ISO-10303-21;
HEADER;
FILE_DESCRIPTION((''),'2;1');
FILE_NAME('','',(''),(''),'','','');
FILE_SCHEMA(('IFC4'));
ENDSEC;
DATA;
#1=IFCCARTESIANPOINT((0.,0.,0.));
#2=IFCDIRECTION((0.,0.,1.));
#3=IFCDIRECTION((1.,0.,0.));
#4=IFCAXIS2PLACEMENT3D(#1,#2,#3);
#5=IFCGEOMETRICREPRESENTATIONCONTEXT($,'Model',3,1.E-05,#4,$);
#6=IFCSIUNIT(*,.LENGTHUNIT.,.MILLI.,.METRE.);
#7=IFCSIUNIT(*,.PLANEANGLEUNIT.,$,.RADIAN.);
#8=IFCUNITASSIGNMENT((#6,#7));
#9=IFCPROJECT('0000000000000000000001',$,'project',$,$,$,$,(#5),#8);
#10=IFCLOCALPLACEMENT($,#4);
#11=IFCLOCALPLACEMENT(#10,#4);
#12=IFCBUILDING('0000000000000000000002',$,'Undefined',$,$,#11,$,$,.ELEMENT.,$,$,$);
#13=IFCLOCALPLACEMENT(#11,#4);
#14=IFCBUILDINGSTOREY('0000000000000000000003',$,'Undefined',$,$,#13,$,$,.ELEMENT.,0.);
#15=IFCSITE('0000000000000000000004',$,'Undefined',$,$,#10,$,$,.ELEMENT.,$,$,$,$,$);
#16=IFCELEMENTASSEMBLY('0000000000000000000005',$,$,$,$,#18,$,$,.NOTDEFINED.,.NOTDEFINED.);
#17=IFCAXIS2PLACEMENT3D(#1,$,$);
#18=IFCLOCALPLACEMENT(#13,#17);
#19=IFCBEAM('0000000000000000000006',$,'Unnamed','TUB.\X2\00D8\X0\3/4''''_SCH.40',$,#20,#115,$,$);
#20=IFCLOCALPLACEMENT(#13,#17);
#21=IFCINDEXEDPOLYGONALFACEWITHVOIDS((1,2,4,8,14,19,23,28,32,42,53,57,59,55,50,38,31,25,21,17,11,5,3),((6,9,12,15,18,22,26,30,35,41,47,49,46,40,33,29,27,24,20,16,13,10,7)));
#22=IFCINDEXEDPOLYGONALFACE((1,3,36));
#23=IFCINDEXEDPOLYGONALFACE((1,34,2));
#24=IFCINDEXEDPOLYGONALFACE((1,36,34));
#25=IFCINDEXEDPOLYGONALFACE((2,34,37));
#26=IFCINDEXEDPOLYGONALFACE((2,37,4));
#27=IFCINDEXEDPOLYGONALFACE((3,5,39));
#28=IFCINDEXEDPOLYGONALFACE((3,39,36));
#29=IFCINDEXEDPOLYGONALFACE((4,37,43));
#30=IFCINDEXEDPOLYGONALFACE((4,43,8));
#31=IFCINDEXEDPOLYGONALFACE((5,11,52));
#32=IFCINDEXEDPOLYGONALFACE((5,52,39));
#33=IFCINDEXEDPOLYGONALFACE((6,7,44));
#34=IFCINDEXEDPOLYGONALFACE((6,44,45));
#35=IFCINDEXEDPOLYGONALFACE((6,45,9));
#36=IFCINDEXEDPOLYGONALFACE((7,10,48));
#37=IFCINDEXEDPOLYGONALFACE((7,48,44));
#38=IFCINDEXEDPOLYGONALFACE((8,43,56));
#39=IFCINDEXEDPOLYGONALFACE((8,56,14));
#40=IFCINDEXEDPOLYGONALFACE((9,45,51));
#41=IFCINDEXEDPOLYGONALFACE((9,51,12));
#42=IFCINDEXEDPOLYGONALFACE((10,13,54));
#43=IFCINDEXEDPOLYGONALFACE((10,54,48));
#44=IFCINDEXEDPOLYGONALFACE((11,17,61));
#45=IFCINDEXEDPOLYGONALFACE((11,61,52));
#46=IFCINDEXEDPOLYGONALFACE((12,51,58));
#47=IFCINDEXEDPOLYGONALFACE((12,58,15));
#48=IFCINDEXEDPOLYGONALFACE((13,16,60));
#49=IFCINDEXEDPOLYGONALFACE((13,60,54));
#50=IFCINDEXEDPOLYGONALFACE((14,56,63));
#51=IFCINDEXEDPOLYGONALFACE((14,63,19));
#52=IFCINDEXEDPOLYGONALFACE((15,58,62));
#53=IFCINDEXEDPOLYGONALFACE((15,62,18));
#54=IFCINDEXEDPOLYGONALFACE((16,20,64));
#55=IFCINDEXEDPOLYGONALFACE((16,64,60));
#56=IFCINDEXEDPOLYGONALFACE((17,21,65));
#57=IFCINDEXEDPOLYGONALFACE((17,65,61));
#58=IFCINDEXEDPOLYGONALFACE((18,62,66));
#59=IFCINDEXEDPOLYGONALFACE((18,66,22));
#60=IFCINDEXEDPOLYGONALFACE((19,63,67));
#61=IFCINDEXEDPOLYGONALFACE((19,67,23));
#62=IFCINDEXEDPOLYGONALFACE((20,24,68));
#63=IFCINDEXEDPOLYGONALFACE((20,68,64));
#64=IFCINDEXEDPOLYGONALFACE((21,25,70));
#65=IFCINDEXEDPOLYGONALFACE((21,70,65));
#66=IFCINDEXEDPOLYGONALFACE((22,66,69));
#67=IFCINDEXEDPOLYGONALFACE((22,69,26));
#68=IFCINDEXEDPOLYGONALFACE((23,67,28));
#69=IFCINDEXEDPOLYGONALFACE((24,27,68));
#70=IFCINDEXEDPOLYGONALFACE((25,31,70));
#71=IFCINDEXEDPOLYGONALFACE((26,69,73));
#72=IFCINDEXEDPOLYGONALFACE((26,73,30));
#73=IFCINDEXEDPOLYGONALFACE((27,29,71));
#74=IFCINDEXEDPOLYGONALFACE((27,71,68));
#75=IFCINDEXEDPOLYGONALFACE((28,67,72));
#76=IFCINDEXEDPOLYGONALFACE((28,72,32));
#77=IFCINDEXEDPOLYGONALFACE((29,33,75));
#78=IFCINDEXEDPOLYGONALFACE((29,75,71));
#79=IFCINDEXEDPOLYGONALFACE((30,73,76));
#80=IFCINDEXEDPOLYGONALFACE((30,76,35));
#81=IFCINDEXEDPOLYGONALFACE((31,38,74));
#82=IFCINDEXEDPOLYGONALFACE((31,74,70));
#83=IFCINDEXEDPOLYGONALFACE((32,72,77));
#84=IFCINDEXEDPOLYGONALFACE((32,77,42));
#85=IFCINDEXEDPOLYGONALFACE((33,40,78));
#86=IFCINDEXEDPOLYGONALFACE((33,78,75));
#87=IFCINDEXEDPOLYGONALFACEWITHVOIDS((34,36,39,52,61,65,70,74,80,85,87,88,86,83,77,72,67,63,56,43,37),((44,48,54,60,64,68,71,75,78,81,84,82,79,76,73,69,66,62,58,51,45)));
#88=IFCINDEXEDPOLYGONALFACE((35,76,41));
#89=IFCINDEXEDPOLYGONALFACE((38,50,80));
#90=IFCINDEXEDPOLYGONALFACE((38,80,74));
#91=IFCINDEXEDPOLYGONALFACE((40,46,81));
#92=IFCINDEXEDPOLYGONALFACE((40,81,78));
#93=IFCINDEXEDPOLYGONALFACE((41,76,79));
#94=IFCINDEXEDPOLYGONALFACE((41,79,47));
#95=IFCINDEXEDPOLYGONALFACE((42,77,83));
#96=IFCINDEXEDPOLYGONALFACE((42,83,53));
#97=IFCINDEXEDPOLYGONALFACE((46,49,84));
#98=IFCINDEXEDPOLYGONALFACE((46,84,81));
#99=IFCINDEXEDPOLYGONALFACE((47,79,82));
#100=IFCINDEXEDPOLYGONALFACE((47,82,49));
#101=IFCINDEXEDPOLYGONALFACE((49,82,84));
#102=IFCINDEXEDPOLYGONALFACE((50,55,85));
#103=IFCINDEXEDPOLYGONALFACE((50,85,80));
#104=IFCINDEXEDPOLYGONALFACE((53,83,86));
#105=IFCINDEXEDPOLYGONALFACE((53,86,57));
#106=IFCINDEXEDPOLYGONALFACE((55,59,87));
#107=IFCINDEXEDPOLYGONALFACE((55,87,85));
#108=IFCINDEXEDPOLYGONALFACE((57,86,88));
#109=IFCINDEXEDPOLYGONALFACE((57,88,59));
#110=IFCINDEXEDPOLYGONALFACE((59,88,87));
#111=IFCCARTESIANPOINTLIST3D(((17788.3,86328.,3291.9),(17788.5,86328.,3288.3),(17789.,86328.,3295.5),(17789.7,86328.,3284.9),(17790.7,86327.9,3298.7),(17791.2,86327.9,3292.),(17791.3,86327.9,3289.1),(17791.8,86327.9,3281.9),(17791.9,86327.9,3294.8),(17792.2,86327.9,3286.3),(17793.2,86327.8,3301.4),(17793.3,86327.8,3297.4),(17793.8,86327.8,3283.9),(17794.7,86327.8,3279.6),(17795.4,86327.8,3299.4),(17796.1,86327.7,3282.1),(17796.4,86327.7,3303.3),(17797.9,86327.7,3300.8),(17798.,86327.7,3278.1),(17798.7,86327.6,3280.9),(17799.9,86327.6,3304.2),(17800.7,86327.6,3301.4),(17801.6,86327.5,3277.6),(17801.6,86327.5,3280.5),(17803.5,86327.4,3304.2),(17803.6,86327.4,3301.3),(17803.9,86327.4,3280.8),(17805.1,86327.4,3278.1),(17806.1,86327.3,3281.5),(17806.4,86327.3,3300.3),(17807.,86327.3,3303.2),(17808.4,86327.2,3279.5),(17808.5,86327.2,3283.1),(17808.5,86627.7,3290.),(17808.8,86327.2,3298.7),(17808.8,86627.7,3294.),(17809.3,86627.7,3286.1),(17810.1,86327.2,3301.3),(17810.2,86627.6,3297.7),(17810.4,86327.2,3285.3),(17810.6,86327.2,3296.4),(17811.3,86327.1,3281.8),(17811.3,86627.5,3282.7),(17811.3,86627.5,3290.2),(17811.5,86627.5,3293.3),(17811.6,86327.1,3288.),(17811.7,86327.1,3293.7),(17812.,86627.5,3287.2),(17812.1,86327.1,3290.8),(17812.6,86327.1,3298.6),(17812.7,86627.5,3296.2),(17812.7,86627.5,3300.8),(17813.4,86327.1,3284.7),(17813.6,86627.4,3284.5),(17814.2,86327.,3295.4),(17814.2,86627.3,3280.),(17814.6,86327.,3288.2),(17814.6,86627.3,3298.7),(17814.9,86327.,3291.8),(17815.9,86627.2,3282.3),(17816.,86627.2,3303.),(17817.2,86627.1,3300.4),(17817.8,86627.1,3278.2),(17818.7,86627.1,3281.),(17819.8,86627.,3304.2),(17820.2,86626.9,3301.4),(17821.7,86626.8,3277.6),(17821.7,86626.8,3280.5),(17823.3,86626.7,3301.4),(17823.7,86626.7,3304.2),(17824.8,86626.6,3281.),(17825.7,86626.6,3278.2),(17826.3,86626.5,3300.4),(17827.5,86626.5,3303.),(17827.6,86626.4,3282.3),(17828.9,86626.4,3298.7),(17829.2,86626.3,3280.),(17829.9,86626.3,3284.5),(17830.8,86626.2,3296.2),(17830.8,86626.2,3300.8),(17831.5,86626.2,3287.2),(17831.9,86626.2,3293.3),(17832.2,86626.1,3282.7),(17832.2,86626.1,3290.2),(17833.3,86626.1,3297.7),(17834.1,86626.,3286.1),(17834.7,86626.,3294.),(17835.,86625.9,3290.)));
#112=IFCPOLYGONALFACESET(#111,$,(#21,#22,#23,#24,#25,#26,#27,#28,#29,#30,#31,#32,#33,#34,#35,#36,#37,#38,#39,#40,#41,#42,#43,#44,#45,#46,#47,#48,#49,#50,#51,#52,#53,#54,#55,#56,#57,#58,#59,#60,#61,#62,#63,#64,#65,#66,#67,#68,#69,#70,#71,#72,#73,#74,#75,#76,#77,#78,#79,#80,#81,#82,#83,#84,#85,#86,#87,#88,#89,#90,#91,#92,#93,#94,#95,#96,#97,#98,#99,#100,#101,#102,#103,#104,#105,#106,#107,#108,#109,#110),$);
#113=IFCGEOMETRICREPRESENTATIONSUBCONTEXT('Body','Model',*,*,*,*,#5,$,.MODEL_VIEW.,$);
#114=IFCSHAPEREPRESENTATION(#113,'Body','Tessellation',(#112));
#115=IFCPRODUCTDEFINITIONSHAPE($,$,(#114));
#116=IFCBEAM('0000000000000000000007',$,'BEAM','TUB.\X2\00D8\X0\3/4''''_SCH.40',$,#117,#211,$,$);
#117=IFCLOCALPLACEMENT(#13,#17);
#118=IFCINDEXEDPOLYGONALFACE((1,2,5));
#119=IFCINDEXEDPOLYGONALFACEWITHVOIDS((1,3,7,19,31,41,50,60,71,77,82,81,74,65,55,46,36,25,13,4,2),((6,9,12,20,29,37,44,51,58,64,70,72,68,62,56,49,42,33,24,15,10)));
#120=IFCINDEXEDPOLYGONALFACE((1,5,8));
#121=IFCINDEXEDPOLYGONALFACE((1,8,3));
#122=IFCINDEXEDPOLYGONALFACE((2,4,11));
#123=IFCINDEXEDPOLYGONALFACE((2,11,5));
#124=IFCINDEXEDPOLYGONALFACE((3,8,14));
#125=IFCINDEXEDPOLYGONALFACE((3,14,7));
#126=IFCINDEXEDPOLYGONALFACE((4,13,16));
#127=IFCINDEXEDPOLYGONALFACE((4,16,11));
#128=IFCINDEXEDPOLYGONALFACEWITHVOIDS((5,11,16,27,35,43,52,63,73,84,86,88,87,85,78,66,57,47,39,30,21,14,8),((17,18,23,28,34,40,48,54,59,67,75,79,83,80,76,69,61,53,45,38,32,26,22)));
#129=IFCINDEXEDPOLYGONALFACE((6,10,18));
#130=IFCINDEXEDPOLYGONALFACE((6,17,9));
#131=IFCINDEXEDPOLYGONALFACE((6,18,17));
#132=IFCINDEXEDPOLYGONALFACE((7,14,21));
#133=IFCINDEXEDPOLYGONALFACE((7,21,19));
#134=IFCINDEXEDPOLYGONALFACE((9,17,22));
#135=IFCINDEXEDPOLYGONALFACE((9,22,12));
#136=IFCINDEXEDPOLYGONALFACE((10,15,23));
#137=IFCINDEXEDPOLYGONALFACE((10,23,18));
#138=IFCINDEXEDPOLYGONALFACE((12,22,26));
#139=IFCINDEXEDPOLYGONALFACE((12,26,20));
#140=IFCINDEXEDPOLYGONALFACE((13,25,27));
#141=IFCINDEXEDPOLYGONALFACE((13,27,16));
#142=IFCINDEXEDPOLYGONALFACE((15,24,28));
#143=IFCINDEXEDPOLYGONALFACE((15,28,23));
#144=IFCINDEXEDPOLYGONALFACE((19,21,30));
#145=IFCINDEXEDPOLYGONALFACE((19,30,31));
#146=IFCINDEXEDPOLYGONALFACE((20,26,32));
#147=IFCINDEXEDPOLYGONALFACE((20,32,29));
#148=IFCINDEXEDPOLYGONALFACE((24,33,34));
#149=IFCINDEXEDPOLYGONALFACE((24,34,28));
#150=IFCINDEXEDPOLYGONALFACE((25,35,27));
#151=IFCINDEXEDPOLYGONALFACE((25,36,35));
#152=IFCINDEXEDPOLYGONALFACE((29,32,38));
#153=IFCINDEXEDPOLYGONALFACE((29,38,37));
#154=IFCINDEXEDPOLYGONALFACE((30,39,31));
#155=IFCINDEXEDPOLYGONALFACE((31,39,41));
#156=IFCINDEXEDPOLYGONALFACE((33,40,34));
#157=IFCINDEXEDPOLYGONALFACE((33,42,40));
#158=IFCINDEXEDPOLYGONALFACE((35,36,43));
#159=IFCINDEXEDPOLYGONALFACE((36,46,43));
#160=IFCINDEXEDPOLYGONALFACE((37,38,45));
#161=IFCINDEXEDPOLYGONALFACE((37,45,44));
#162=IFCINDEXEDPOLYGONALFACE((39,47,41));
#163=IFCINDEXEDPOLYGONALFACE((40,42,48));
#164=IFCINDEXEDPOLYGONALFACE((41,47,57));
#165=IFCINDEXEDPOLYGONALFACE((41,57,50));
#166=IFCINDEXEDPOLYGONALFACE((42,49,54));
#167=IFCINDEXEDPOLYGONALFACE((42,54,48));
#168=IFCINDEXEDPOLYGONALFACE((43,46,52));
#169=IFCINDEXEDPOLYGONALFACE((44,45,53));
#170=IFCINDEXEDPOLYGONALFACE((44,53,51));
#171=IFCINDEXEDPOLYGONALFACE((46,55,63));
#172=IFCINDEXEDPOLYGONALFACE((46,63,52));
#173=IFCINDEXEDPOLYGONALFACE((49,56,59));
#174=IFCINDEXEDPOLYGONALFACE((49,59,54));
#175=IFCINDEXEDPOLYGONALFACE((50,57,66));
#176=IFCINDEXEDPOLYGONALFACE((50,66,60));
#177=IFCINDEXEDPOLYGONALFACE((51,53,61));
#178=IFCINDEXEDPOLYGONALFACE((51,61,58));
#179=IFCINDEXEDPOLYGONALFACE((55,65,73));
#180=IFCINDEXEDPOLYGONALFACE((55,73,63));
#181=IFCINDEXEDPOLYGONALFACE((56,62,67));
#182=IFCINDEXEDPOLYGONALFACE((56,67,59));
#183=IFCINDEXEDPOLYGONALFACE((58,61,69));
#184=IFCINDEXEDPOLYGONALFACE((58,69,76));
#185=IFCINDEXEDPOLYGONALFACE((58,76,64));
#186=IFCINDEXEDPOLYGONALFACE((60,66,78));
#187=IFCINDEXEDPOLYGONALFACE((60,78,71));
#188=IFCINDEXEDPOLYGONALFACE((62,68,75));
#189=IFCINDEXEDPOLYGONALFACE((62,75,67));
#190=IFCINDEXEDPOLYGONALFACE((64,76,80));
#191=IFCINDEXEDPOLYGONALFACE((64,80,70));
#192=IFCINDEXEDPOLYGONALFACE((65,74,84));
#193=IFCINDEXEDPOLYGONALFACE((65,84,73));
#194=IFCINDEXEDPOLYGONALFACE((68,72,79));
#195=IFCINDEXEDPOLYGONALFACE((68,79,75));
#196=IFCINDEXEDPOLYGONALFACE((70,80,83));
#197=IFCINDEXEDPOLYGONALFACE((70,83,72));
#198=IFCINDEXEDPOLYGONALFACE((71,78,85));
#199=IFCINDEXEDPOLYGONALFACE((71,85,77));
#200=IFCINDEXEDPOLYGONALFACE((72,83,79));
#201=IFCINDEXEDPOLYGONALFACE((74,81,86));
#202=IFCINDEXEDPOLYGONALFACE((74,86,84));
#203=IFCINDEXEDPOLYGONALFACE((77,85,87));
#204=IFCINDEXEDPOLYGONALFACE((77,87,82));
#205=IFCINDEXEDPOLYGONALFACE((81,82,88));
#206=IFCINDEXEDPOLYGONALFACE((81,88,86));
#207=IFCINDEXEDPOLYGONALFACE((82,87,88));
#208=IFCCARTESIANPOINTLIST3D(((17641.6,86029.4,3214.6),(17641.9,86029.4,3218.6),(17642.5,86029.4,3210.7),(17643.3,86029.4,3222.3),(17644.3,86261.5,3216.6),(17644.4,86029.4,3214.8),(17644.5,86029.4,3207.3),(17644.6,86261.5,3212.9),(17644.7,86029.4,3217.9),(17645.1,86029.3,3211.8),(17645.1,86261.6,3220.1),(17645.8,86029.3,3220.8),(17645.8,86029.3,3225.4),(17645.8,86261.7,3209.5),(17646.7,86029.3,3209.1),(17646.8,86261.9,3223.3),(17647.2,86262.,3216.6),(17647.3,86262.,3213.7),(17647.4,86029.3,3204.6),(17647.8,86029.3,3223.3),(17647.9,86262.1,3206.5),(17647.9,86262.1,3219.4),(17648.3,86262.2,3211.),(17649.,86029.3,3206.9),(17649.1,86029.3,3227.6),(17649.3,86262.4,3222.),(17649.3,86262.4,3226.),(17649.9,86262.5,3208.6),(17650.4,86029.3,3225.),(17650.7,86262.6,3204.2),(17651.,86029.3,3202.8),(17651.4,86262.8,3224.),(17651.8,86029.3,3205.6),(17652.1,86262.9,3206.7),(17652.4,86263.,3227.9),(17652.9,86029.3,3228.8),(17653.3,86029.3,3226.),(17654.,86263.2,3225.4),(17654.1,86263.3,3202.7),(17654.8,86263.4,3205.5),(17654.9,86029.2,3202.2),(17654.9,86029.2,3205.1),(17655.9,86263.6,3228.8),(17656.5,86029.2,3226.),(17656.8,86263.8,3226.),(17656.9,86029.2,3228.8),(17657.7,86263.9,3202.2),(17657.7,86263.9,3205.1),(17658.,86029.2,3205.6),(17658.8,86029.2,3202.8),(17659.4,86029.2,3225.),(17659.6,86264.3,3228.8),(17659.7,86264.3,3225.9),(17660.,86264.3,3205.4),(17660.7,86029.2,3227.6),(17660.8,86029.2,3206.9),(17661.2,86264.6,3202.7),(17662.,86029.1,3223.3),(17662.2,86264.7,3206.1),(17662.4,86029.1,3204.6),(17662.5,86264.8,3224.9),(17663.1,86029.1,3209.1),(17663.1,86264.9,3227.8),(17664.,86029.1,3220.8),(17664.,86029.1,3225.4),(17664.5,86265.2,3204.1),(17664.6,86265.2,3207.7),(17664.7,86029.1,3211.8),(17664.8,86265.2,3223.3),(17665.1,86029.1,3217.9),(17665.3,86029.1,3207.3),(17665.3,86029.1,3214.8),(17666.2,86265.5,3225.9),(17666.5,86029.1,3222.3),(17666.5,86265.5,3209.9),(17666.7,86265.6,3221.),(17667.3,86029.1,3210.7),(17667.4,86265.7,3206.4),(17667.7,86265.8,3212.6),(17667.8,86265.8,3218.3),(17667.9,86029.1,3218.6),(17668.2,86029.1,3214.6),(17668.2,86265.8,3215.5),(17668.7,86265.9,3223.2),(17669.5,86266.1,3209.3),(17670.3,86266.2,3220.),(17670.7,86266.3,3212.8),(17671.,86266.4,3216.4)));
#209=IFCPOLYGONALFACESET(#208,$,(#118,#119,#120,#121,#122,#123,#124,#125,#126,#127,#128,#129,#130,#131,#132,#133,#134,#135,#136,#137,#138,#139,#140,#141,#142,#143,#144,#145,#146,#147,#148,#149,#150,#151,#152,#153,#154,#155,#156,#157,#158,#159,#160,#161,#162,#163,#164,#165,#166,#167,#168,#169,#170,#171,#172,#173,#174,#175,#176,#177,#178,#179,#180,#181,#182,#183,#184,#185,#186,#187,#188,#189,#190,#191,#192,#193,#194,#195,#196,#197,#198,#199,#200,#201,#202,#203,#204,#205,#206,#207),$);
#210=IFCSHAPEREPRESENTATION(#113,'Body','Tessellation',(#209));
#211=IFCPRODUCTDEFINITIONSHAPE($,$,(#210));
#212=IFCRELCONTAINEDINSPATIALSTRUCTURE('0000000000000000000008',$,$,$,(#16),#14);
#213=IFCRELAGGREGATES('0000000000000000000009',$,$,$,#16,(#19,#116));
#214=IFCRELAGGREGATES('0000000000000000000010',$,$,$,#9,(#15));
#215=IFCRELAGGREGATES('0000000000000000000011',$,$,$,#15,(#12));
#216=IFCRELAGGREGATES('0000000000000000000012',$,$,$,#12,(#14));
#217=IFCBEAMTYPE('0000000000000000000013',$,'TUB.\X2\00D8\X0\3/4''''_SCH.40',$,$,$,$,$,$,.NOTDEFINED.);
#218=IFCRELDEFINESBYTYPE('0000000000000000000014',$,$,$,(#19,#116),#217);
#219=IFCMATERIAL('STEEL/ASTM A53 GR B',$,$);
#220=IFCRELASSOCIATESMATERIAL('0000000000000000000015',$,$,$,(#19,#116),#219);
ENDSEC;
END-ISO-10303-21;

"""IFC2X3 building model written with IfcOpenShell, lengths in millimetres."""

from ifc_helpers import new_model, si_unit, frame, origin_with_axes, origin_2d_with_axis, place, context, subcontext, project, spatial, hollow_circle, extrude, clip, halfspace, material, type_object, element, aggregate, save


model = new_model("IFC2X3")

# Units and contexts
model_context = context("Model", 3, precision=1e-05, world=origin_with_axes())
body_context = subcontext(model_context, "Body", "Model", "MODEL_VIEW")
ifc_project = project(units=[si_unit("LENGTHUNIT", "METRE", prefix="MILLI"), si_unit("PLANEANGLEUNIT", "RADIAN")], contexts=[model_context])

# Site, building, storey
site_placement = place(None, origin_with_axes())
site = spatial("IfcSite", under=ifc_project, at=site_placement, Name="Undefined", CompositionType="ELEMENT")
building_placement = place(site_placement, origin_with_axes())
building = spatial("IfcBuilding", under=site, at=building_placement, Name="Undefined", CompositionType="ELEMENT")
storey_placement = place(building_placement, origin_with_axes())
storey = spatial("IfcBuildingStorey", under=building, at=storey_placement, Name="Undefined", CompositionType="ELEMENT", Elevation=0.0)

# Element assembly, beams
assembly_placement = place(storey_placement, origin_with_axes())
assembly = element("IfcElementAssembly", 1, at=assembly_placement, inside=storey, AssemblyPlace="NOTDEFINED", PredefinedType="NOTDEFINED")
ifc_material_1 = material(Name="STEEL/ASTM A53 GR B")
beam_type_1 = type_object("IfcBeamType", Name="TUB.Ø3/4''_SCH.40", PredefinedType="NOTDEFINED")
beam_1_placement = place(assembly_placement, frame((17821.7, 86626.8, 3291.0), z_axis=(-0.997745, 0.067123, 0.0), x_axis=(-0.067123, -0.997745, 0.0)))
beam_1 = element("IfcBeam", 2, at=beam_1_placement, type_object=beam_type_1, material=ifc_material_1, Name="Unnamed", Description="TUB.Ø3/4''_SCH.40", context=body_context, shape_type="Clipping", body=[
    clip(clip(extrude(hollow_circle(Radius=13.3, WallThickness=2.9, at=origin_2d_with_axis()), frame((303.2, 0.0, 0.0), z_axis=(-1.0, 0.0, 0.0), x_axis=(0.0, -1.0, 0.0)), (0.0, 0.0, 1.0), 306.5), halfspace(frame((299.6, 0.0, -13.3), z_axis=(-0.999617, 0.0, 0.027664), x_axis=(0.0, 1.0, 0.0)), True)), halfspace(frame((0.0, -13.4, 0.0), z_axis=(1.0, 0.0, 0.0), x_axis=(0.0, 0.0, 1.0)), True)),
])
beam_2_placement = place(assembly_placement, frame((17654.9, 86029.2, 3215.6), z_axis=(0.99993, -0.011821, 0.0), x_axis=(0.011821, 0.99993, 0.0)))
beam_2 = element("IfcBeam", 3, at=beam_2_placement, type_object=beam_type_1, material=ifc_material_1, Name="BEAM", Description="TUB.Ø3/4''_SCH.40", context=body_context, shape_type="Clipping", body=[
    clip(clip(extrude(hollow_circle(Radius=13.3, WallThickness=2.9, at=origin_2d_with_axis()), frame((311.4, 0.0, 0.0), z_axis=(-1.0, 0.0, 0.0), x_axis=(0.0, -1.0, 0.0)), (0.0, 0.0, 1.0), 314.3), halfspace(frame((232.1, 0.0, -13.3), z_axis=(0.981535, 0.000002, -0.191284), x_axis=(0.0, -1.0, -0.000013)), False)), halfspace(frame((0.0, -13.4, 0.0), z_axis=(1.0, 0.0, 0.0), x_axis=(0.0, 0.0, 1.0)), True)),
])
aggregate(assembly, [beam_1, beam_2])

save(model, "model.ifc")
